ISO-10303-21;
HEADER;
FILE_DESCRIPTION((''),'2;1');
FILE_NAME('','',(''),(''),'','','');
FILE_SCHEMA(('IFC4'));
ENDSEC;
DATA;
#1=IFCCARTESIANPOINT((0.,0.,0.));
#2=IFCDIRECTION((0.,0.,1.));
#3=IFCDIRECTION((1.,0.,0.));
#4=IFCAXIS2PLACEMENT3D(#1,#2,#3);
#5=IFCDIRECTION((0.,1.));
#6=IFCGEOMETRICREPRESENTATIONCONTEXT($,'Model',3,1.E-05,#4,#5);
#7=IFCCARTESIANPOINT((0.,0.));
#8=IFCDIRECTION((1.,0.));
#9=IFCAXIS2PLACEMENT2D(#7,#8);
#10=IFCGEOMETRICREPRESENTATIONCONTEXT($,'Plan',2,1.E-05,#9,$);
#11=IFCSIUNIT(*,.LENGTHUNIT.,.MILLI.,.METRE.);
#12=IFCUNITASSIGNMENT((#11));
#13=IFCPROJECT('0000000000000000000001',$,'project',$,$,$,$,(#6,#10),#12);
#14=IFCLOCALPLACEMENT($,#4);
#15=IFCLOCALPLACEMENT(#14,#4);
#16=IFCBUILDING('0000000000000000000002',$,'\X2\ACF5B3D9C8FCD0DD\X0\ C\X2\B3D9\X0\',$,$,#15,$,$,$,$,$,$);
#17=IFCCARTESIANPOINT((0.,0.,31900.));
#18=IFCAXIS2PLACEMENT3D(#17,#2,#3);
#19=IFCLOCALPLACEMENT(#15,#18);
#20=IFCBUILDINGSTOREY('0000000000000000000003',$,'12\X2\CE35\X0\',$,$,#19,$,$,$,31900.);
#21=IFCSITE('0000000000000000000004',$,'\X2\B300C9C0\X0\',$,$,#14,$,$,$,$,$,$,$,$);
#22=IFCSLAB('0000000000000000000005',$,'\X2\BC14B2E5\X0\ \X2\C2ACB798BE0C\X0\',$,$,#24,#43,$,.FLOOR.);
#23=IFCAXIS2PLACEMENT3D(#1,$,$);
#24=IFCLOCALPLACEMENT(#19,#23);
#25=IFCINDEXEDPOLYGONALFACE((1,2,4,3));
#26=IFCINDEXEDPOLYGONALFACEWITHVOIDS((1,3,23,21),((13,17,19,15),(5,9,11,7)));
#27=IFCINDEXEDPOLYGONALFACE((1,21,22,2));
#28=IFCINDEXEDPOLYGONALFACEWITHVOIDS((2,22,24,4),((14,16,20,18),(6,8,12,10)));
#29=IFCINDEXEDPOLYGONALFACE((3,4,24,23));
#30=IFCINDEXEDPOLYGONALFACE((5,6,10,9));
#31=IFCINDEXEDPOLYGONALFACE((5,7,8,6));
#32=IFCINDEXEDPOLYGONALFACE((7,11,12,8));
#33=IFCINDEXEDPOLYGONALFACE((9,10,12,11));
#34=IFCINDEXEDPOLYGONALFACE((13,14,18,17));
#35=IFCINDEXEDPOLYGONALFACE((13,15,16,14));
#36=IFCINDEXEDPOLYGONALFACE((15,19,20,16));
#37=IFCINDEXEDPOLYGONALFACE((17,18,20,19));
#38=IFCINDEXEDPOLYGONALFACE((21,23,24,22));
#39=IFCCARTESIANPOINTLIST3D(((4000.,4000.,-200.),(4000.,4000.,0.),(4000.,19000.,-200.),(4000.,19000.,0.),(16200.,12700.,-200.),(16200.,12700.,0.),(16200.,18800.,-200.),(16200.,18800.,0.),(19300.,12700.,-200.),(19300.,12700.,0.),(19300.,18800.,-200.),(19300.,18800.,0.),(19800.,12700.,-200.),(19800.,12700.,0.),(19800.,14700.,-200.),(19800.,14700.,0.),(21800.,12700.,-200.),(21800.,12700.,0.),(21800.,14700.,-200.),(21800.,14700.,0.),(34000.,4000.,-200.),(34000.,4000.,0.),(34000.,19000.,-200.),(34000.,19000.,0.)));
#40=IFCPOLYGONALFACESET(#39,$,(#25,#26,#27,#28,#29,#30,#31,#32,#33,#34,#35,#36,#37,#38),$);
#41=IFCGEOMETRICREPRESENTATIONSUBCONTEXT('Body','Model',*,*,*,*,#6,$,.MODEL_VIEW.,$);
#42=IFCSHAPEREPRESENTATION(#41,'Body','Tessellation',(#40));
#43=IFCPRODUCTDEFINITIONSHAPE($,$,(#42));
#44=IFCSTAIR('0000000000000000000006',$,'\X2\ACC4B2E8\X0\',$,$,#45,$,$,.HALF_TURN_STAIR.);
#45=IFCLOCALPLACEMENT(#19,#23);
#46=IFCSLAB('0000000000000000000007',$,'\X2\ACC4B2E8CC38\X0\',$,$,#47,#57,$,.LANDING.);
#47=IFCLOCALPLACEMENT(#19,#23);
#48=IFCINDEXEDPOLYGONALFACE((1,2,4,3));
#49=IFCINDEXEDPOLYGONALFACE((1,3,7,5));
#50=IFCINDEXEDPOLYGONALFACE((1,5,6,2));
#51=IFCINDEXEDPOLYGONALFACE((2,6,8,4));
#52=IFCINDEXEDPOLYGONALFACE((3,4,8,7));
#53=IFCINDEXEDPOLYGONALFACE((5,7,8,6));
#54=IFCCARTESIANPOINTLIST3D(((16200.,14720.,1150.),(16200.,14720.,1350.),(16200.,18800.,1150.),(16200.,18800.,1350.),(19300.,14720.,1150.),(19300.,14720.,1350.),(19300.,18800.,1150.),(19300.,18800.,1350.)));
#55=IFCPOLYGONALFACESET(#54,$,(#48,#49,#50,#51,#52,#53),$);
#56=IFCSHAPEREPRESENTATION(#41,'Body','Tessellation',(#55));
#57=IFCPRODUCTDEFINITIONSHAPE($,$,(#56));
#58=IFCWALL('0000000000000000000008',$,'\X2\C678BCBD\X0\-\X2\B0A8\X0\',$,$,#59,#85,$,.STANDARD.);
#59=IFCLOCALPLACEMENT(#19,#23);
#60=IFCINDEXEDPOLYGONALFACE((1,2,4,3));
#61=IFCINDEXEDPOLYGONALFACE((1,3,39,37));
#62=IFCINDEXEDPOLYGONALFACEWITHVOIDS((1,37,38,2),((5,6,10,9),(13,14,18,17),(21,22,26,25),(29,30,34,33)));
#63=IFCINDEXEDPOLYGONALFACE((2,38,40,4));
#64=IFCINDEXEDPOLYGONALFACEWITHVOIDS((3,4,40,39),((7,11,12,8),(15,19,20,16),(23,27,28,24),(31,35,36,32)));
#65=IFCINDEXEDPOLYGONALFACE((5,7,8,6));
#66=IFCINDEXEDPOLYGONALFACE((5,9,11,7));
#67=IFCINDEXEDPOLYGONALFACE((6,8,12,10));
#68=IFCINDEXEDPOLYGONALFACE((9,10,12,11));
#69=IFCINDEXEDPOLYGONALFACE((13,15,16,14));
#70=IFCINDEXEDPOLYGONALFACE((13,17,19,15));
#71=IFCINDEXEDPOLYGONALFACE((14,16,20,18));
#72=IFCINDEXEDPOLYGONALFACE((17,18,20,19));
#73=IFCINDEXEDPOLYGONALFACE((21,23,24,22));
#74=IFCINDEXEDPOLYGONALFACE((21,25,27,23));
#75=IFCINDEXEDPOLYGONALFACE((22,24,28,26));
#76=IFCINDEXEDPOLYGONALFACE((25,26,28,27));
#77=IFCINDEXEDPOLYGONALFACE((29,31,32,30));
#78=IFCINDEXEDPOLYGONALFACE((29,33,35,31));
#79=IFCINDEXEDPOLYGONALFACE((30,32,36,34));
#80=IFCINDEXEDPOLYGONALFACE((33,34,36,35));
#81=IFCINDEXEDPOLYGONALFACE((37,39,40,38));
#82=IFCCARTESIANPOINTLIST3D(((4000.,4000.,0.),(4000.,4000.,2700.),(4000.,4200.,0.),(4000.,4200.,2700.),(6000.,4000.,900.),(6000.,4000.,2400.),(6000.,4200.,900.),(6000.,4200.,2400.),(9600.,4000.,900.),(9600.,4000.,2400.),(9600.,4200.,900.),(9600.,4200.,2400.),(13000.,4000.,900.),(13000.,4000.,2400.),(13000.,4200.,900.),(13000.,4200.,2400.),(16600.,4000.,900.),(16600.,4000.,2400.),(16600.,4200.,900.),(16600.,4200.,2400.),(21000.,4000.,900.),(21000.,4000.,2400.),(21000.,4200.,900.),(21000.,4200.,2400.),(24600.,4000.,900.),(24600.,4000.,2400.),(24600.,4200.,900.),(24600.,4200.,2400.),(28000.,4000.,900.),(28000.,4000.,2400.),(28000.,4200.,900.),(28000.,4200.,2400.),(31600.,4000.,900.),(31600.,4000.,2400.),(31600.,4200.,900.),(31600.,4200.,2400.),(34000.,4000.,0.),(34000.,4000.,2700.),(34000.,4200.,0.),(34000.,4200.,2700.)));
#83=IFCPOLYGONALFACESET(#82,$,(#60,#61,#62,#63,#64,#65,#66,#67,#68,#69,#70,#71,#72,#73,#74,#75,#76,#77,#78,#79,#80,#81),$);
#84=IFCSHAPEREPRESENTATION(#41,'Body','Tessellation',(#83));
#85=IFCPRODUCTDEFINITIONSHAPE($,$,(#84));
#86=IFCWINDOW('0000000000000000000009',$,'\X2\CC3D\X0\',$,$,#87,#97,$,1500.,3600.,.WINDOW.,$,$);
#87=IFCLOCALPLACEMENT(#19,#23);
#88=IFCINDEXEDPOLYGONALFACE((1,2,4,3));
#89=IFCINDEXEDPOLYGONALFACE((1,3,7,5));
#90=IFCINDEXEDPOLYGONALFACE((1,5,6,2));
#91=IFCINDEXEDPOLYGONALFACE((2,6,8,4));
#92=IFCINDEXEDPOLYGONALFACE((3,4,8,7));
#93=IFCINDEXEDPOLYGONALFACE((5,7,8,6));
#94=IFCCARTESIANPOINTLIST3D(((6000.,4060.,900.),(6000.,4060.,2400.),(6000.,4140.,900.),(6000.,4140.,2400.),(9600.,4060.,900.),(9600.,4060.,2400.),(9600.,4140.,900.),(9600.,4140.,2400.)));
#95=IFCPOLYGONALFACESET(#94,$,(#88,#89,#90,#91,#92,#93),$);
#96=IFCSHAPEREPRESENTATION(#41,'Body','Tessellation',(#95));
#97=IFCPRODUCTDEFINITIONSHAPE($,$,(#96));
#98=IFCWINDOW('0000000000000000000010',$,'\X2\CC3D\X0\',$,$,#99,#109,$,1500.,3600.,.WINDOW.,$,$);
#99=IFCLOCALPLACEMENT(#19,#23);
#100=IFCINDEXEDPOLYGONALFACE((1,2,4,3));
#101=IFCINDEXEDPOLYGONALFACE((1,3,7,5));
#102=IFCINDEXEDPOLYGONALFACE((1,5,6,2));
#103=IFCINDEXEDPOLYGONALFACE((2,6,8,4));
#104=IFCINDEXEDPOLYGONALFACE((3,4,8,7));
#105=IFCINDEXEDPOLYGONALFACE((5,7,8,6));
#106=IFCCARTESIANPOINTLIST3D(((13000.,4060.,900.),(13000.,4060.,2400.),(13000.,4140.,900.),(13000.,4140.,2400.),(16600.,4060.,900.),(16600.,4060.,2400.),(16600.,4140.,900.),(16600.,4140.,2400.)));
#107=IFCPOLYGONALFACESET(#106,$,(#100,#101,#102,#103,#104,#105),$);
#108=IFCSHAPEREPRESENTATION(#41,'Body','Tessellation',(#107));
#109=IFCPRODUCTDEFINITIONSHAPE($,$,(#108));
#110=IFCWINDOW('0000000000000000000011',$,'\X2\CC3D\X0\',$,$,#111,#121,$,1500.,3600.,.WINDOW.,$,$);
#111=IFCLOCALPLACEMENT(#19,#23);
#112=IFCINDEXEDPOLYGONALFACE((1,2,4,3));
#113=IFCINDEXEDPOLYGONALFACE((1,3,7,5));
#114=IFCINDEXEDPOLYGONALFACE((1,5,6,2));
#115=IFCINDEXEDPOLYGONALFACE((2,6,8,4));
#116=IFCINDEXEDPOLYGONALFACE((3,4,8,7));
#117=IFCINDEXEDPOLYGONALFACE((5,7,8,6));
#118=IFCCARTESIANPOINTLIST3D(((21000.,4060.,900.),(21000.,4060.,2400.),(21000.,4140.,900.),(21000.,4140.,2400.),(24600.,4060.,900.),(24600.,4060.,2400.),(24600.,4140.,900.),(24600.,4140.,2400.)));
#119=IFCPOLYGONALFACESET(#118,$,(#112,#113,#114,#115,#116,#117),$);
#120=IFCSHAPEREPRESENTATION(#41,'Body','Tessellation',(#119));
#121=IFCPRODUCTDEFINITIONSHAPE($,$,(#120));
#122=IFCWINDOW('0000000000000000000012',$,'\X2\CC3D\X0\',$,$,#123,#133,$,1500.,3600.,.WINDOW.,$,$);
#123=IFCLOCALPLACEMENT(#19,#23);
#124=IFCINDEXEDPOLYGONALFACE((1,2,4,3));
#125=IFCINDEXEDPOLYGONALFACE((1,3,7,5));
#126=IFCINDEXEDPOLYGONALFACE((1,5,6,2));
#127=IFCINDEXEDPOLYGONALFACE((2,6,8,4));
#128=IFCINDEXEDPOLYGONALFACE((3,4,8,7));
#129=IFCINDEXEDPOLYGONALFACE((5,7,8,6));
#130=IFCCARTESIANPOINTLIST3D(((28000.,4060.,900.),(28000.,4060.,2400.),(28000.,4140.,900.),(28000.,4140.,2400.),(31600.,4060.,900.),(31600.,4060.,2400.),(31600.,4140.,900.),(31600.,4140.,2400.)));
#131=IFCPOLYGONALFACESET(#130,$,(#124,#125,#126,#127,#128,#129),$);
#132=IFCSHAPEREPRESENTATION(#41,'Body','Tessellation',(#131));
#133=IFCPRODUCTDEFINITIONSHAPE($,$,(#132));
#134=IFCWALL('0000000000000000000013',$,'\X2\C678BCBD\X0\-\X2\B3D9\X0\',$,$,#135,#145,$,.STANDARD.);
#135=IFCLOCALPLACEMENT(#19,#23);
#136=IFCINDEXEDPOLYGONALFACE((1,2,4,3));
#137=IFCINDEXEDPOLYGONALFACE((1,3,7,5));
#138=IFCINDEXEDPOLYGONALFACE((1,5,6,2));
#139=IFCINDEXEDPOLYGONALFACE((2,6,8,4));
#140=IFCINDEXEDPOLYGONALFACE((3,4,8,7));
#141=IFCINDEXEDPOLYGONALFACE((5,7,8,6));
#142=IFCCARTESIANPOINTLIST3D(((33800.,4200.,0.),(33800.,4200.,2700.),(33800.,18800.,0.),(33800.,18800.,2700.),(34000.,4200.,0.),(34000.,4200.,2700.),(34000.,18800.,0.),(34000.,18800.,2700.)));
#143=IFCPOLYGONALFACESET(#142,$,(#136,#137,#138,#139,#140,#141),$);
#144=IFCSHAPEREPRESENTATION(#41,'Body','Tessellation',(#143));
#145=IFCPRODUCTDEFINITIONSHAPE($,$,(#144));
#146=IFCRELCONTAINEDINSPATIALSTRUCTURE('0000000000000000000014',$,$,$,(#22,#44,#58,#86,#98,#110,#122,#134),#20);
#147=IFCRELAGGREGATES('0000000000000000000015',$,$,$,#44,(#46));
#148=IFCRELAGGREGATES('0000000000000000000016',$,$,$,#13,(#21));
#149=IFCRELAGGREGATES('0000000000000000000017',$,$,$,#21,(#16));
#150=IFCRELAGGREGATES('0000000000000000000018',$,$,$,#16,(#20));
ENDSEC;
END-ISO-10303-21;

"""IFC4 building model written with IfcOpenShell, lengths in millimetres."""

from ifc_helpers import new_model, si_unit, direction, frame, origin_with_axes, origin_2d_with_axis, place, context, subcontext, project, spatial, polyline, outline, extrude, element, fill, aggregate, save


model = new_model("IFC4")

# Units and contexts
model_context = context("Model", 3, precision=1e-05, world=origin_with_axes(), true_north=direction((0.0, 1.0)))
plan_context = context("Plan", 2, precision=1e-05, world=origin_2d_with_axis())
body_context = subcontext(model_context, "Body", "Model", "MODEL_VIEW")
ifc_project = project(units=[si_unit("LENGTHUNIT", "METRE", prefix="MILLI")], contexts=[model_context, plan_context])

# Site, building, storey
site_placement = place(None, origin_with_axes())
site = spatial("IfcSite", under=ifc_project, at=site_placement, Name="대지")
building_placement = place(site_placement, origin_with_axes())
building = spatial("IfcBuilding", under=site, at=building_placement, Name="공동주택 C동")
storey_placement = place(building_placement, frame((0.0, 0.0, 31900.0), z_axis=(0.0, 0.0, 1.0), x_axis=(1.0, 0.0, 0.0)))
storey = spatial("IfcBuildingStorey", under=building, at=storey_placement, Name="12층", Elevation=31900.0)

# Slab
slab_1_placement = place(storey_placement, origin_with_axes())
element("IfcSlab", 1, at=slab_1_placement, inside=storey, Name="바닥 슬래브", PredefinedType="FLOOR", context=body_context, shape_type="SweptSolid", body=[
    extrude(outline(polyline([(4000.0, 4000.0), (34000.0, 4000.0), (34000.0, 19000.0), (4000.0, 19000.0), (4000.0, 4000.0)]), holes=[polyline([(16200.0, 12700.0), (19300.0, 12700.0), (19300.0, 18800.0), (16200.0, 18800.0), (16200.0, 12700.0)]), polyline([(19800.0, 12700.0), (21800.0, 12700.0), (21800.0, 14700.0), (19800.0, 14700.0), (19800.0, 12700.0)])]), frame((0.0, 0.0, -200.0), z_axis=(0.0, 0.0, 1.0), x_axis=(1.0, 0.0, 0.0)), (0.0, 0.0, 1.0), 200.0),
])

# Stair, slab
stair_placement = place(storey_placement, origin_with_axes())
stair = element("IfcStair", 2, at=stair_placement, inside=storey, Name="계단", PredefinedType="HALF_TURN_STAIR")
slab_2_placement = place(stair_placement, origin_with_axes())
slab_2 = element("IfcSlab", 3, at=slab_2_placement, Name="계단참", PredefinedType="LANDING", context=body_context, shape_type="SweptSolid", body=[
    extrude(outline(polyline([(16200.0, 14720.0), (19300.0, 14720.0), (19300.0, 18800.0), (16200.0, 18800.0), (16200.0, 14720.0)])), frame((0.0, 0.0, 1150.0), z_axis=(0.0, 0.0, 1.0), x_axis=(1.0, 0.0, 0.0)), (0.0, 0.0, 1.0), 200.0),
])

# Wall, openings, windows
wall_1_placement = place(storey_placement, origin_with_axes())
wall_1 = element("IfcWall", 4, at=wall_1_placement, inside=storey, Name="외벽-남", PredefinedType="STANDARD", context=body_context, shape_type="SweptSolid", body=[
    extrude(outline(polyline([(4000.0, 4200.0), (34000.0, 4200.0), (34000.0, 4000.0), (4000.0, 4000.0), (4000.0, 4200.0)])), origin_with_axes(), (0.0, 0.0, 1.0), 2700.0),
])
opening_1_placement = place(storey_placement, origin_with_axes())
opening_1 = element("IfcOpeningElement", 5, at=opening_1_placement, cuts=wall_1, PredefinedType="OPENING", context=body_context, shape_type="SweptSolid", body=[
    extrude(outline(polyline([(6000.0, 3950.0), (9600.0, 3950.0), (9600.0, 4250.0), (6000.0, 4250.0), (6000.0, 3950.0)])), frame((0.0, 0.0, 900.0), z_axis=(0.0, 0.0, 1.0), x_axis=(1.0, 0.0, 0.0)), (0.0, 0.0, 1.0), 1500.0),
])
opening_2_placement = place(storey_placement, origin_with_axes())
opening_2 = element("IfcOpeningElement", 6, at=opening_2_placement, cuts=wall_1, PredefinedType="OPENING", context=body_context, shape_type="SweptSolid", body=[
    extrude(outline(polyline([(13000.0, 3950.0), (16600.0, 3950.0), (16600.0, 4250.0), (13000.0, 4250.0), (13000.0, 3950.0)])), frame((0.0, 0.0, 900.0), z_axis=(0.0, 0.0, 1.0), x_axis=(1.0, 0.0, 0.0)), (0.0, 0.0, 1.0), 1500.0),
])
opening_3_placement = place(storey_placement, origin_with_axes())
opening_3 = element("IfcOpeningElement", 7, at=opening_3_placement, cuts=wall_1, PredefinedType="OPENING", context=body_context, shape_type="SweptSolid", body=[
    extrude(outline(polyline([(21000.0, 3950.0), (24600.0, 3950.0), (24600.0, 4250.0), (21000.0, 4250.0), (21000.0, 3950.0)])), frame((0.0, 0.0, 900.0), z_axis=(0.0, 0.0, 1.0), x_axis=(1.0, 0.0, 0.0)), (0.0, 0.0, 1.0), 1500.0),
])
opening_4_placement = place(storey_placement, origin_with_axes())
opening_4 = element("IfcOpeningElement", 8, at=opening_4_placement, cuts=wall_1, PredefinedType="OPENING", context=body_context, shape_type="SweptSolid", body=[
    extrude(outline(polyline([(28000.0, 3950.0), (31600.0, 3950.0), (31600.0, 4250.0), (28000.0, 4250.0), (28000.0, 3950.0)])), frame((0.0, 0.0, 900.0), z_axis=(0.0, 0.0, 1.0), x_axis=(1.0, 0.0, 0.0)), (0.0, 0.0, 1.0), 1500.0),
])
window_1_placement = place(storey_placement, origin_with_axes())
window_1 = element("IfcWindow", 9, at=window_1_placement, inside=storey, Name="창", OverallHeight=1500.0, OverallWidth=3600.0, PredefinedType="WINDOW", context=body_context, shape_type="SweptSolid", body=[
    extrude(outline(polyline([(6000.0, 4060.0), (9600.0, 4060.0), (9600.0, 4140.0), (6000.0, 4140.0), (6000.0, 4060.0)])), frame((0.0, 0.0, 900.0), z_axis=(0.0, 0.0, 1.0), x_axis=(1.0, 0.0, 0.0)), (0.0, 0.0, 1.0), 1500.0),
])
fill(opening_1, window_1)
window_2_placement = place(storey_placement, origin_with_axes())
window_2 = element("IfcWindow", 10, at=window_2_placement, inside=storey, Name="창", OverallHeight=1500.0, OverallWidth=3600.0, PredefinedType="WINDOW", context=body_context, shape_type="SweptSolid", body=[
    extrude(outline(polyline([(13000.0, 4060.0), (16600.0, 4060.0), (16600.0, 4140.0), (13000.0, 4140.0), (13000.0, 4060.0)])), frame((0.0, 0.0, 900.0), z_axis=(0.0, 0.0, 1.0), x_axis=(1.0, 0.0, 0.0)), (0.0, 0.0, 1.0), 1500.0),
])
fill(opening_2, window_2)
window_3_placement = place(storey_placement, origin_with_axes())
window_3 = element("IfcWindow", 11, at=window_3_placement, inside=storey, Name="창", OverallHeight=1500.0, OverallWidth=3600.0, PredefinedType="WINDOW", context=body_context, shape_type="SweptSolid", body=[
    extrude(outline(polyline([(21000.0, 4060.0), (24600.0, 4060.0), (24600.0, 4140.0), (21000.0, 4140.0), (21000.0, 4060.0)])), frame((0.0, 0.0, 900.0), z_axis=(0.0, 0.0, 1.0), x_axis=(1.0, 0.0, 0.0)), (0.0, 0.0, 1.0), 1500.0),
])
fill(opening_3, window_3)
window_4_placement = place(storey_placement, origin_with_axes())
window_4 = element("IfcWindow", 12, at=window_4_placement, inside=storey, Name="창", OverallHeight=1500.0, OverallWidth=3600.0, PredefinedType="WINDOW", context=body_context, shape_type="SweptSolid", body=[
    extrude(outline(polyline([(28000.0, 4060.0), (31600.0, 4060.0), (31600.0, 4140.0), (28000.0, 4140.0), (28000.0, 4060.0)])), frame((0.0, 0.0, 900.0), z_axis=(0.0, 0.0, 1.0), x_axis=(1.0, 0.0, 0.0)), (0.0, 0.0, 1.0), 1500.0),
])
fill(opening_4, window_4)

# Wall
wall_2_placement = place(storey_placement, origin_with_axes())
element("IfcWall", 13, at=wall_2_placement, inside=storey, Name="외벽-동", PredefinedType="STANDARD", context=body_context, shape_type="SweptSolid", body=[
    extrude(outline(polyline([(33800.0, 4200.0), (33800.0, 18800.0), (34000.0, 18800.0), (34000.0, 4200.0), (33800.0, 4200.0)])), origin_with_axes(), (0.0, 0.0, 1.0), 2700.0),
])

aggregate(stair, [slab_2])

save(model, "model.ifc")
